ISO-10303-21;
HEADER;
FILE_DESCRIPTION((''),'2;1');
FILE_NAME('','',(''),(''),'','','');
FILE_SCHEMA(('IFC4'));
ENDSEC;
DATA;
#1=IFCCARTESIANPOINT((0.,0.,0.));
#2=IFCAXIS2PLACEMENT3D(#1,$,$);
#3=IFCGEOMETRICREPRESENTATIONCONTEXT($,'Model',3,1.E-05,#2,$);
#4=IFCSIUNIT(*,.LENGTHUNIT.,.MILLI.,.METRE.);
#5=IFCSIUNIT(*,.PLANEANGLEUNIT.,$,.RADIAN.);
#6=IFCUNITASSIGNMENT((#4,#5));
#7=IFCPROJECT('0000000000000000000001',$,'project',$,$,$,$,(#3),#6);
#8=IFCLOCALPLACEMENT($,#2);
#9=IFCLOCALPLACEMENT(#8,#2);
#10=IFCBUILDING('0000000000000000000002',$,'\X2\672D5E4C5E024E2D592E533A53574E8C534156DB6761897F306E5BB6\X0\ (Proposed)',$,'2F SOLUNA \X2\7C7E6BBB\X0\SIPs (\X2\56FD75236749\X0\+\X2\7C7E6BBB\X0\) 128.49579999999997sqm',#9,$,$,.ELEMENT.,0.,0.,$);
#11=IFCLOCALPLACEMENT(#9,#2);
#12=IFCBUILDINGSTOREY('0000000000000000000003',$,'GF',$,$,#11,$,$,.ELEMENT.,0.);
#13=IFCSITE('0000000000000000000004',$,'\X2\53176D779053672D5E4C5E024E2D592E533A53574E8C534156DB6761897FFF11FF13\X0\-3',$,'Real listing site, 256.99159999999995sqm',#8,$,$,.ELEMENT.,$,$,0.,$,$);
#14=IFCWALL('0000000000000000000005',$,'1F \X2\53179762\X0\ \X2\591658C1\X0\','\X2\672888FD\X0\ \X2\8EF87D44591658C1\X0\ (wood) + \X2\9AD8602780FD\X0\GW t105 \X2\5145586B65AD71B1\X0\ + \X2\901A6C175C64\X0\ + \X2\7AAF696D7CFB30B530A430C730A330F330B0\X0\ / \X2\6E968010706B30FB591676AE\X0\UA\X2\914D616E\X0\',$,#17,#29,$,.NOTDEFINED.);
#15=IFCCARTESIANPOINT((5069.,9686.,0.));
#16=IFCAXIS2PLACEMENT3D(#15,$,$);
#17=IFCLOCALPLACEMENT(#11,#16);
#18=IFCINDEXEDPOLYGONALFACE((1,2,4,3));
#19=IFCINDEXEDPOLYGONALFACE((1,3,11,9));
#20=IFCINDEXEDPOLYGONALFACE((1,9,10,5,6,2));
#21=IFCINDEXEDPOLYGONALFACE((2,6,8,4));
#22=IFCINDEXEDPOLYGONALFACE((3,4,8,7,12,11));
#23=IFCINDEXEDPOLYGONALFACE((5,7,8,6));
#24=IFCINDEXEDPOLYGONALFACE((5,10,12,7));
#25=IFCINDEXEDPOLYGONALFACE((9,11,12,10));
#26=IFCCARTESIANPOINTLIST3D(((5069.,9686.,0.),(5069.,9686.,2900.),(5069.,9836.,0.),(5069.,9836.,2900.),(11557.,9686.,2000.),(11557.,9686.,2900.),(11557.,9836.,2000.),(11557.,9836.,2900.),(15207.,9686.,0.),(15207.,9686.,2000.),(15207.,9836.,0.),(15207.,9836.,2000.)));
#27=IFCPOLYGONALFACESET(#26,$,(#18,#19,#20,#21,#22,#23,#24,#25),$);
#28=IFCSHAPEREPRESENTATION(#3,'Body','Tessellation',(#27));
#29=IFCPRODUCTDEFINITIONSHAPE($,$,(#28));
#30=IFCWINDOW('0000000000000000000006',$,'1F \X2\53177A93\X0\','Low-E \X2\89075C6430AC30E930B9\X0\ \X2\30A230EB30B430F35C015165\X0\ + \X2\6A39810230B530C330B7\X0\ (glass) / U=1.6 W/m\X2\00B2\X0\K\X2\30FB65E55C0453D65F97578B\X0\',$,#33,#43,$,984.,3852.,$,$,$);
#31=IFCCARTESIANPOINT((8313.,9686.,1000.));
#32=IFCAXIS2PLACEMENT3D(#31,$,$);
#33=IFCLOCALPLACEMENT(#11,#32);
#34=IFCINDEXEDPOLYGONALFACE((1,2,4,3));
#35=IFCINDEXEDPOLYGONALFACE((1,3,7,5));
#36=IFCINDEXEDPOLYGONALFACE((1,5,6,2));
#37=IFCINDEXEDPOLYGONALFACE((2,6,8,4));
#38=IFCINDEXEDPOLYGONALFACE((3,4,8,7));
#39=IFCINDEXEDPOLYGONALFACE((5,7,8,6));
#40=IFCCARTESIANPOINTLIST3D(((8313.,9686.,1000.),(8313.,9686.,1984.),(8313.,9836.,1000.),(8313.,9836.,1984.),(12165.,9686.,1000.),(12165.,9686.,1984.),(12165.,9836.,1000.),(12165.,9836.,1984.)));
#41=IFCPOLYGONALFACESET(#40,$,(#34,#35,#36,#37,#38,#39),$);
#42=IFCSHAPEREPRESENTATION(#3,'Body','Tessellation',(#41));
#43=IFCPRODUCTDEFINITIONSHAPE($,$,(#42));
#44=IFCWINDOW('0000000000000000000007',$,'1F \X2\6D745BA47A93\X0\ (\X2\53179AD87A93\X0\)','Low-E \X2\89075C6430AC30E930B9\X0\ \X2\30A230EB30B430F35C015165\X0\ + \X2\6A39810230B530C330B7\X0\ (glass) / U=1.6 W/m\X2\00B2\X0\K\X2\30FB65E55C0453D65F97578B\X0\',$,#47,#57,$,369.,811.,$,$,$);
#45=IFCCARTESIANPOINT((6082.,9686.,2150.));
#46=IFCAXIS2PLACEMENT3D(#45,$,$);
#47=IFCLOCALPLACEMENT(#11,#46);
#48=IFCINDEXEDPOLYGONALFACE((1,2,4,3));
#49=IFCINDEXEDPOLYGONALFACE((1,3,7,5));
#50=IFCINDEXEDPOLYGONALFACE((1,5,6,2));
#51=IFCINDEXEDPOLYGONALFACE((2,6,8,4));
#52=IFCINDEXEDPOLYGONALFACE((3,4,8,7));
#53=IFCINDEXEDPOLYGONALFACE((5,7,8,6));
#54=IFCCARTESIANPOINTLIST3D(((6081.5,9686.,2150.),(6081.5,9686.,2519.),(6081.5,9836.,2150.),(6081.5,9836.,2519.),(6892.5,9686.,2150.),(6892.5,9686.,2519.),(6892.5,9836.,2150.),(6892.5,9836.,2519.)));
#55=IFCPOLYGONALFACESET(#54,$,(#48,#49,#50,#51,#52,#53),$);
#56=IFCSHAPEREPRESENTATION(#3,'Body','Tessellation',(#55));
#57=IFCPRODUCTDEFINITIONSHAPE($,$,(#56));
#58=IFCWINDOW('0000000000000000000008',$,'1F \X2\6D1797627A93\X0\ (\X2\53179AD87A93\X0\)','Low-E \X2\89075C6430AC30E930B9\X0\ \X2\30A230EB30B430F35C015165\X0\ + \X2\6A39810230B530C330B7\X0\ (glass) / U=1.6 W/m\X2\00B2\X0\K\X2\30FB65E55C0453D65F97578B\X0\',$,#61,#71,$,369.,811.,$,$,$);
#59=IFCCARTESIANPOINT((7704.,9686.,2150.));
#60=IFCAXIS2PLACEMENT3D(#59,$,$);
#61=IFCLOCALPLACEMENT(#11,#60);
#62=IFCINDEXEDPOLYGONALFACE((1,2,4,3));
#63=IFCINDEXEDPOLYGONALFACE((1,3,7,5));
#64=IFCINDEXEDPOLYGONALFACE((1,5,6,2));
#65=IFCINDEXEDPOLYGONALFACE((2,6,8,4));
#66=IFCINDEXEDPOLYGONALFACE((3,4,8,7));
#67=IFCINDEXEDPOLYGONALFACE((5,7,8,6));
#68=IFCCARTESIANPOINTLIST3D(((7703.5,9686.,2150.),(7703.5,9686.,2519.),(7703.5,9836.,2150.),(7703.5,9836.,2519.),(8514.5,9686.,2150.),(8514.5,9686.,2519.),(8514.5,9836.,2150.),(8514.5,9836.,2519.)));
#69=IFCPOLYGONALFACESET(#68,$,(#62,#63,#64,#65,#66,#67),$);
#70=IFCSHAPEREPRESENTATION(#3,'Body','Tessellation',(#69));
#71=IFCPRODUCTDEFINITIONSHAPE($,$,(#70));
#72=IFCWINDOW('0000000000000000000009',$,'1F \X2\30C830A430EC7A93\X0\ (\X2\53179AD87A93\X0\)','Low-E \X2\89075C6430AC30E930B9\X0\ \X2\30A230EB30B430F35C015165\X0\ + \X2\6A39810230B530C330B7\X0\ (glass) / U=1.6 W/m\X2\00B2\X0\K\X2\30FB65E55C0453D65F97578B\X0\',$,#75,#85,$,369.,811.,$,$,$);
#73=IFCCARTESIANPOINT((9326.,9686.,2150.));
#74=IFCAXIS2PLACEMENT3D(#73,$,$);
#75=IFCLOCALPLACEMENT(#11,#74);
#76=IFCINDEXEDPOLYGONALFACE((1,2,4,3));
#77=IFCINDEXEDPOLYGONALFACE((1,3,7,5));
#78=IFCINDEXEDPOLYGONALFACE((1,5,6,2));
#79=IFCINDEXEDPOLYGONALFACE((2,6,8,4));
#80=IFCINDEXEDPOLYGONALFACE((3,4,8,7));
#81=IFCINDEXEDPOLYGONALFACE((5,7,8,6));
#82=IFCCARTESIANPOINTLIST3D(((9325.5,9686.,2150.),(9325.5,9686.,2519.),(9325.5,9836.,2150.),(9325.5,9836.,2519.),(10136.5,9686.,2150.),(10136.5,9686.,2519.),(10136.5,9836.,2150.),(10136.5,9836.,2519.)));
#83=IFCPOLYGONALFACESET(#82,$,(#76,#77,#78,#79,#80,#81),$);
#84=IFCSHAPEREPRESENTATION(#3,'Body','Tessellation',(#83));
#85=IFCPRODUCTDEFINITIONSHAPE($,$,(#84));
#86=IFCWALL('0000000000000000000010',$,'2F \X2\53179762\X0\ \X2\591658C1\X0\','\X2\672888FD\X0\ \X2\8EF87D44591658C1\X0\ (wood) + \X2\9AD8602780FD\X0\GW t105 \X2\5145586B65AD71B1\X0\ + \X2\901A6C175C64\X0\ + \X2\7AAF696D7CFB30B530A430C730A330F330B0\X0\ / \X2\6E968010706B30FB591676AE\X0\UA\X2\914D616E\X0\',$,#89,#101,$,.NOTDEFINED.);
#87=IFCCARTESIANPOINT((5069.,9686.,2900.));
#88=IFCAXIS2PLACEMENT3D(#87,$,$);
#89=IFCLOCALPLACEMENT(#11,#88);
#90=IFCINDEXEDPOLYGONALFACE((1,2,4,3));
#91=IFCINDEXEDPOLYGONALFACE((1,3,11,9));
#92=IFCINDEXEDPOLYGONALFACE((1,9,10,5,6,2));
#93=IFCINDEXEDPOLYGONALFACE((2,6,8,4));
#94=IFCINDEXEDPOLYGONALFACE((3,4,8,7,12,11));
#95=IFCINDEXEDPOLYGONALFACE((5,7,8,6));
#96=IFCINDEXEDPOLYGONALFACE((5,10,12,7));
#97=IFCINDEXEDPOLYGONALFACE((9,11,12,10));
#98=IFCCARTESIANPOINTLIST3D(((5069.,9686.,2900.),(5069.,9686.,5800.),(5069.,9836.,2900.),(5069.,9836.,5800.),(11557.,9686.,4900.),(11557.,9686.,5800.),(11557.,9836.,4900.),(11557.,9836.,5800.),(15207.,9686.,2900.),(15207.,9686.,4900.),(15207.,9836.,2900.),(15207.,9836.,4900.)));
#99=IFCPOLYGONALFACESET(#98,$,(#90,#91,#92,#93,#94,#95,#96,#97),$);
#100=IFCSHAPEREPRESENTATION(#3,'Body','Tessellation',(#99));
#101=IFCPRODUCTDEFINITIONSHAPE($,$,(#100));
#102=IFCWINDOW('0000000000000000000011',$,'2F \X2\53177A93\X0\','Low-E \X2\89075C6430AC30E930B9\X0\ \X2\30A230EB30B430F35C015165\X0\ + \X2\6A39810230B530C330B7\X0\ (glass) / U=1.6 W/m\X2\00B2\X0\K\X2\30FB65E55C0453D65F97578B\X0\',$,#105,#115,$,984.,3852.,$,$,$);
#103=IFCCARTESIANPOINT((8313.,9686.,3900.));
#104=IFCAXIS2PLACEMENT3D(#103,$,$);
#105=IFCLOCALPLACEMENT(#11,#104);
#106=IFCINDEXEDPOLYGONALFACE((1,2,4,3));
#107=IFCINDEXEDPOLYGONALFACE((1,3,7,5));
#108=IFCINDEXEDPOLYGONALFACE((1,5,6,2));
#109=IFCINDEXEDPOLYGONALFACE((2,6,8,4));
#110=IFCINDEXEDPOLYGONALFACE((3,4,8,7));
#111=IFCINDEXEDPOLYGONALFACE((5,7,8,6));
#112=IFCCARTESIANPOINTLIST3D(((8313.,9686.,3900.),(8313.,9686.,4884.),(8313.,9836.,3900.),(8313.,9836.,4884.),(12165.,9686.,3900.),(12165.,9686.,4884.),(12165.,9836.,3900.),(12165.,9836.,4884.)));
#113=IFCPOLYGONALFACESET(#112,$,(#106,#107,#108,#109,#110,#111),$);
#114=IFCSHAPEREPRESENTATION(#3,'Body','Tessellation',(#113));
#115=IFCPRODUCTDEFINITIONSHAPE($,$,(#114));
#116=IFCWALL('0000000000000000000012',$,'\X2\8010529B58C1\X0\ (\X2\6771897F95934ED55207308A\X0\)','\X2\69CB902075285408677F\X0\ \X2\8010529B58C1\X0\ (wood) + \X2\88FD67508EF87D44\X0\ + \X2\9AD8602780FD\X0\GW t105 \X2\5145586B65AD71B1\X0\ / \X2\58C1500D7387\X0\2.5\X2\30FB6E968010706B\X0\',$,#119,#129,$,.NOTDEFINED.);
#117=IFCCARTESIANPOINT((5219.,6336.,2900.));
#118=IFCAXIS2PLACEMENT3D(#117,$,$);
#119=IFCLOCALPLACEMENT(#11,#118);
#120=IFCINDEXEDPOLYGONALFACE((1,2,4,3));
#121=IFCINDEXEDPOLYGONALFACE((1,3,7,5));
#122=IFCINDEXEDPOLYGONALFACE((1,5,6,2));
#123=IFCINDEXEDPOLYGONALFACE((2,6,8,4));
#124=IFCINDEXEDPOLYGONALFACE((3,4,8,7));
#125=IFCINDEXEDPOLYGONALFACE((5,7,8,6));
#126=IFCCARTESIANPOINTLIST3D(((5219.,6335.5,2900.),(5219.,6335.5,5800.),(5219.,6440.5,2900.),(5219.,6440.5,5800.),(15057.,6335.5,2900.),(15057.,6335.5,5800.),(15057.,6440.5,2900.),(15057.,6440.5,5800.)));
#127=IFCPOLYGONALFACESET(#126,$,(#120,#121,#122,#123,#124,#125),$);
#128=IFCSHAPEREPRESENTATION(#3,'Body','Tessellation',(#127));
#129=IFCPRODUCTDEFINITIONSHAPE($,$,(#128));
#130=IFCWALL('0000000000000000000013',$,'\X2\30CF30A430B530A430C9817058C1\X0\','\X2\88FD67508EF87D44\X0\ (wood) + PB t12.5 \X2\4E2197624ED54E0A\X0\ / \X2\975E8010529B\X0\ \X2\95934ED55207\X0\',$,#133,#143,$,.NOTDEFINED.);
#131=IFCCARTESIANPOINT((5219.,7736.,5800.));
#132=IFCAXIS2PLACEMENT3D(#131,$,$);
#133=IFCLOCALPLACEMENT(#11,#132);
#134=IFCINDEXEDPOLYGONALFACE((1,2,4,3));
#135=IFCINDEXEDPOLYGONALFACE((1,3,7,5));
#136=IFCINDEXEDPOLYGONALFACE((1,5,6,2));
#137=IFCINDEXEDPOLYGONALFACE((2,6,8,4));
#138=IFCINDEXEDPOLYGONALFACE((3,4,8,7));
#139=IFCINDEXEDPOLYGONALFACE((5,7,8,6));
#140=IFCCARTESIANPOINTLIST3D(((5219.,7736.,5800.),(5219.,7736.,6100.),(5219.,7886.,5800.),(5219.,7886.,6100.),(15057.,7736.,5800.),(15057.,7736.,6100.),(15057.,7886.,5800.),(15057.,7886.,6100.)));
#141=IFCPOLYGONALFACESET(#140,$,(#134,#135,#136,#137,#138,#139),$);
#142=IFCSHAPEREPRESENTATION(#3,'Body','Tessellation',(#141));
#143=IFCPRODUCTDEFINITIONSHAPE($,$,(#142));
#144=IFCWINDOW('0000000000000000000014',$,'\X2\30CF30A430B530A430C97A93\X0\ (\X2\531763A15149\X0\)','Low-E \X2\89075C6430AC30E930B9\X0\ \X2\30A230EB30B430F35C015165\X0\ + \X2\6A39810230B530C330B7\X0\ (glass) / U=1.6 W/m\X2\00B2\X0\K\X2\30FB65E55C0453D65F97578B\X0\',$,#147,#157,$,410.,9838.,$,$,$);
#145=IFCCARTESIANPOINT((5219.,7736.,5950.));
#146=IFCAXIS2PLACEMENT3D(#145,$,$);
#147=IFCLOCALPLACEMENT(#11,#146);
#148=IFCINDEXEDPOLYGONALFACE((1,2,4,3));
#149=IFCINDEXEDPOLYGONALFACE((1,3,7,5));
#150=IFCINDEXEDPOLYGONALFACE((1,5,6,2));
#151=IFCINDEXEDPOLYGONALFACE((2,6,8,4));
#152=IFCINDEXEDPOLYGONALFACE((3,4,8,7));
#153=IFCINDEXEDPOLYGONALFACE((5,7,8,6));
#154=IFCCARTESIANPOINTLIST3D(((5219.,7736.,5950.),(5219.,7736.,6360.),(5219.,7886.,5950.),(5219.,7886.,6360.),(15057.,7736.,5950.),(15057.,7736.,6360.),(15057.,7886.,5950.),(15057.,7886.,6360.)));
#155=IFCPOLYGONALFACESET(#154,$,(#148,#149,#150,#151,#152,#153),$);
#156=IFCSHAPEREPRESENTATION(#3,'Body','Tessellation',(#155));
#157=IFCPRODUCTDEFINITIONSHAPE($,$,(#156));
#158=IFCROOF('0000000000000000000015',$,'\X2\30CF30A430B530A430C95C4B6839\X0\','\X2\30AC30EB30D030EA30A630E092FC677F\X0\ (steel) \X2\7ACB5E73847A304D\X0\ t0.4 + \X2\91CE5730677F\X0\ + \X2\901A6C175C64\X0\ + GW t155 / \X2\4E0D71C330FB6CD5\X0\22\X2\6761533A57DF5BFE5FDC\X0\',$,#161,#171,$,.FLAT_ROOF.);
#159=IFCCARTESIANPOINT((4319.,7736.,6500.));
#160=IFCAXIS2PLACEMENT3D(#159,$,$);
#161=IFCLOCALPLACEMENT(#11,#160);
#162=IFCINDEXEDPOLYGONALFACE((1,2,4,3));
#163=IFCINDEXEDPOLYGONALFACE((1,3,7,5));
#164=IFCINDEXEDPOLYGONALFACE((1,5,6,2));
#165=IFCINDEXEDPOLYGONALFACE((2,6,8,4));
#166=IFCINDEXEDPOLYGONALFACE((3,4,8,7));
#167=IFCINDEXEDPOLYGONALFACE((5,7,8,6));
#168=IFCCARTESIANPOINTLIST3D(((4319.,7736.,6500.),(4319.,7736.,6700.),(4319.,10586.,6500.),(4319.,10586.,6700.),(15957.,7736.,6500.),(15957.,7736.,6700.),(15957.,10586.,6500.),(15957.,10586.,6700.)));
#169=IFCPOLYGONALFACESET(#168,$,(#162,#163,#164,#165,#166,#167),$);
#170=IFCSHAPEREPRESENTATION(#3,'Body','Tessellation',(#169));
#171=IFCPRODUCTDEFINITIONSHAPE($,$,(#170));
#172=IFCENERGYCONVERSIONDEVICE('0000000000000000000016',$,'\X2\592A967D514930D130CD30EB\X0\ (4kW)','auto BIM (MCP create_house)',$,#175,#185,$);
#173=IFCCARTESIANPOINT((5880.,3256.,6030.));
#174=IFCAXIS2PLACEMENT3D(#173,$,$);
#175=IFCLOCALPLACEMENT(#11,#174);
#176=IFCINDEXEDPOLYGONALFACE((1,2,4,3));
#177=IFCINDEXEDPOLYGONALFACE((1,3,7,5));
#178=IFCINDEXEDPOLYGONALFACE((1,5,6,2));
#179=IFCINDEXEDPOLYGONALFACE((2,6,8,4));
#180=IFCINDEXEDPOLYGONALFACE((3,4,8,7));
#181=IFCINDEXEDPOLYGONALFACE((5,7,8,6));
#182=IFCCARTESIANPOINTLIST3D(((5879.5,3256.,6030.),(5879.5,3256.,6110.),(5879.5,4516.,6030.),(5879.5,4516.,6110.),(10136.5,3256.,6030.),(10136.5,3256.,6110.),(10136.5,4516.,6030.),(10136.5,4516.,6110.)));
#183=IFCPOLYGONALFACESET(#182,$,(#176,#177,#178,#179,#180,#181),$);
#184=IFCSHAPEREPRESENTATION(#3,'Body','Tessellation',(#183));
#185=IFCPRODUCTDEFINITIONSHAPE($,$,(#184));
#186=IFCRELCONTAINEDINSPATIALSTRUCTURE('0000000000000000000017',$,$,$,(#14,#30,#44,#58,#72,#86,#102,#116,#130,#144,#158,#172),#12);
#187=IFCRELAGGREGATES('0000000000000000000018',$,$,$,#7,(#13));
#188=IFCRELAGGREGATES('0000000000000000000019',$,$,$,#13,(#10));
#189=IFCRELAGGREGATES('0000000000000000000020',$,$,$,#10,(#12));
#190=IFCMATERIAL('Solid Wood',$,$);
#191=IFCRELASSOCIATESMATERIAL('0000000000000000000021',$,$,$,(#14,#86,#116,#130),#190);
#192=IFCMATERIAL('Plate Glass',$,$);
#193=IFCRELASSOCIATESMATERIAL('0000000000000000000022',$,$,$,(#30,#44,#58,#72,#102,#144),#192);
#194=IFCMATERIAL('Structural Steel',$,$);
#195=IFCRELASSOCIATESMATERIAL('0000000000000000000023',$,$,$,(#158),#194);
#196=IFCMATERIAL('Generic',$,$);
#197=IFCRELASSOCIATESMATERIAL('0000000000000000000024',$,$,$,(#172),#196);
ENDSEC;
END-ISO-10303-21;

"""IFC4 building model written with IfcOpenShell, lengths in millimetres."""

from ifc_helpers import new_model, si_unit, frame, frame_2d, origin, place, context, project, spatial, rectangle, extrude, material, element, fill, save


model = new_model("IFC4")

# Units and contexts
model_context = context("Model", 3, precision=1e-05, world=origin())
ifc_project = project(units=[si_unit("LENGTHUNIT", "METRE", prefix="MILLI"), si_unit("PLANEANGLEUNIT", "RADIAN")], contexts=[model_context])

# Site, building, storey
site_placement = place(None, origin())
site = spatial("IfcSite", under=ifc_project, at=site_placement, Name="北海道札幌市中央区南二十四条西１３-3", ObjectType="Real listing site, 256.99159999999995sqm", CompositionType="ELEMENT", RefElevation=0.0)
building_placement = place(site_placement, origin())
building = spatial("IfcBuilding", under=site, at=building_placement, Name="札幌市中央区南二十四条西の家 (Proposed)", ObjectType="2F SOLUNA 籾殻SIPs (国産杉+籾殻) 128.49579999999997sqm", CompositionType="ELEMENT", ElevationOfRefHeight=0.0, ElevationOfTerrain=0.0)
storey_placement = place(building_placement, origin())
storey = spatial("IfcBuildingStorey", under=building, at=storey_placement, Name="GF", CompositionType="ELEMENT", Elevation=0.0)

# Wall, openings, windows
ifc_material_1 = material(Name="Solid Wood")
wall_1_placement = place(storey_placement, frame((5069.0, 9686.0, 0.0)))
wall_1 = element("IfcWall", 1, at=wall_1_placement, inside=storey, material=ifc_material_1, Name="1F 北面 外壁", Description="木製 軸組外壁 (wood) + 高性能GW t105 充填断熱 + 通気層 + 窯業系サイディング / 準耐火・外皮UA配慮", PredefinedType="NOTDEFINED", context=model_context, shape_type="SweptSolid", body=[
    extrude(rectangle(XDim=10138.0, YDim=150.0, at=frame_2d((5069.0, 75.0))), frame((5069.0, 9686.0, 0.0)), (0.0, 0.0, 1.0), 2900.0),
])
opening_1_placement = place(storey_placement, frame((8313.0, 9686.0, 1000.0)))
opening_1 = element("IfcOpeningElement", 2, at=opening_1_placement, cuts=wall_1, PredefinedType="NOTDEFINED", context=model_context, shape_type="SweptSolid", body=[
    extrude(rectangle(XDim=3852.0, YDim=150.0, at=frame_2d((1926.0, 75.0))), frame((8313.0, 9686.0, 1000.0)), (0.0, 0.0, 1.0), 984.0),
])
opening_2_placement = place(storey_placement, frame((6082.0, 9686.0, 2150.0)))
opening_2 = element("IfcOpeningElement", 3, at=opening_2_placement, cuts=wall_1, PredefinedType="NOTDEFINED", context=model_context, shape_type="SweptSolid", body=[
    extrude(rectangle(XDim=811.0, YDim=150.0, at=frame_2d((405.0, 75.0))), frame((6082.0, 9686.0, 2150.0)), (0.0, 0.0, 1.0), 369.0),
])
opening_3_placement = place(storey_placement, frame((7704.0, 9686.0, 2150.0)))
opening_3 = element("IfcOpeningElement", 4, at=opening_3_placement, cuts=wall_1, PredefinedType="NOTDEFINED", context=model_context, shape_type="SweptSolid", body=[
    extrude(rectangle(XDim=811.0, YDim=150.0, at=frame_2d((405.0, 75.0))), frame((7704.0, 9686.0, 2150.0)), (0.0, 0.0, 1.0), 369.0),
])
opening_4_placement = place(storey_placement, frame((9326.0, 9686.0, 2150.0)))
opening_4 = element("IfcOpeningElement", 5, at=opening_4_placement, cuts=wall_1, PredefinedType="NOTDEFINED", context=model_context, shape_type="SweptSolid", body=[
    extrude(rectangle(XDim=811.0, YDim=150.0, at=frame_2d((405.0, 75.0))), frame((9326.0, 9686.0, 2150.0)), (0.0, 0.0, 1.0), 369.0),
])
ifc_material_2 = material(Name="Plate Glass")
window_1_placement = place(storey_placement, frame((8313.0, 9686.0, 1000.0)))
window_1 = element("IfcWindow", 6, at=window_1_placement, inside=storey, material=ifc_material_2, Name="1F 北窓", Description="Low-E 複層ガラス アルゴン封入 + 樹脂サッシ (glass) / U=1.6 W/m²K・日射取得型", OverallHeight=984.0, OverallWidth=3852.0, context=model_context, shape_type="SweptSolid", body=[
    extrude(rectangle(XDim=3852.0, YDim=150.0, at=frame_2d((1926.0, 75.0))), frame((8313.0, 9686.0, 1000.0)), (0.0, 0.0, 1.0), 984.0),
])
fill(opening_1, window_1)
window_2_placement = place(storey_placement, frame((6082.0, 9686.0, 2150.0)))
window_2 = element("IfcWindow", 7, at=window_2_placement, inside=storey, material=ifc_material_2, Name="1F 浴室窓 (北高窓)", Description="Low-E 複層ガラス アルゴン封入 + 樹脂サッシ (glass) / U=1.6 W/m²K・日射取得型", OverallHeight=369.0, OverallWidth=811.0, context=model_context, shape_type="SweptSolid", body=[
    extrude(rectangle(XDim=811.0, YDim=150.0, at=frame_2d((405.0, 75.0))), frame((6082.0, 9686.0, 2150.0)), (0.0, 0.0, 1.0), 369.0),
])
fill(opening_2, window_2)
window_3_placement = place(storey_placement, frame((7704.0, 9686.0, 2150.0)))
window_3 = element("IfcWindow", 8, at=window_3_placement, inside=storey, material=ifc_material_2, Name="1F 洗面窓 (北高窓)", Description="Low-E 複層ガラス アルゴン封入 + 樹脂サッシ (glass) / U=1.6 W/m²K・日射取得型", OverallHeight=369.0, OverallWidth=811.0, context=model_context, shape_type="SweptSolid", body=[
    extrude(rectangle(XDim=811.0, YDim=150.0, at=frame_2d((405.0, 75.0))), frame((7704.0, 9686.0, 2150.0)), (0.0, 0.0, 1.0), 369.0),
])
fill(opening_3, window_3)
window_4_placement = place(storey_placement, frame((9326.0, 9686.0, 2150.0)))
window_4 = element("IfcWindow", 9, at=window_4_placement, inside=storey, material=ifc_material_2, Name="1F トイレ窓 (北高窓)", Description="Low-E 複層ガラス アルゴン封入 + 樹脂サッシ (glass) / U=1.6 W/m²K・日射取得型", OverallHeight=369.0, OverallWidth=811.0, context=model_context, shape_type="SweptSolid", body=[
    extrude(rectangle(XDim=811.0, YDim=150.0, at=frame_2d((405.0, 75.0))), frame((9326.0, 9686.0, 2150.0)), (0.0, 0.0, 1.0), 369.0),
])
fill(opening_4, window_4)

# Wall, opening, window
wall_2_placement = place(storey_placement, frame((5069.0, 9686.0, 2900.0)))
wall_2 = element("IfcWall", 10, at=wall_2_placement, inside=storey, material=ifc_material_1, Name="2F 北面 外壁", Description="木製 軸組外壁 (wood) + 高性能GW t105 充填断熱 + 通気層 + 窯業系サイディング / 準耐火・外皮UA配慮", PredefinedType="NOTDEFINED", context=model_context, shape_type="SweptSolid", body=[
    extrude(rectangle(XDim=10138.0, YDim=150.0, at=frame_2d((5069.0, 75.0))), frame((5069.0, 9686.0, 2900.0)), (0.0, 0.0, 1.0), 2900.0),
])
opening_5_placement = place(storey_placement, frame((8313.0, 9686.0, 3900.0)))
opening_5 = element("IfcOpeningElement", 11, at=opening_5_placement, cuts=wall_2, PredefinedType="NOTDEFINED", context=model_context, shape_type="SweptSolid", body=[
    extrude(rectangle(XDim=3852.0, YDim=150.0, at=frame_2d((1926.0, 75.0))), frame((8313.0, 9686.0, 3900.0)), (0.0, 0.0, 1.0), 984.0),
])
window_5_placement = place(storey_placement, frame((8313.0, 9686.0, 3900.0)))
window_5 = element("IfcWindow", 12, at=window_5_placement, inside=storey, material=ifc_material_2, Name="2F 北窓", Description="Low-E 複層ガラス アルゴン封入 + 樹脂サッシ (glass) / U=1.6 W/m²K・日射取得型", OverallHeight=984.0, OverallWidth=3852.0, context=model_context, shape_type="SweptSolid", body=[
    extrude(rectangle(XDim=3852.0, YDim=150.0, at=frame_2d((1926.0, 75.0))), frame((8313.0, 9686.0, 3900.0)), (0.0, 0.0, 1.0), 984.0),
])
fill(opening_5, window_5)

# Wall
wall_3_placement = place(storey_placement, frame((5219.0, 6336.0, 2900.0)))
element("IfcWall", 13, at=wall_3_placement, inside=storey, material=ifc_material_1, Name="耐力壁 (東西間仕切り)", Description="構造用合板 耐力壁 (wood) + 製材軸組 + 高性能GW t105 充填断熱 / 壁倍率2.5・準耐火", PredefinedType="NOTDEFINED", context=model_context, shape_type="SweptSolid", body=[
    extrude(rectangle(XDim=9838.0, YDim=105.0, at=frame_2d((4919.0, 52.0))), frame((5219.0, 6336.0, 2900.0)), (0.0, 0.0, 1.0), 2900.0),
])

# Wall, opening, window
wall_4_placement = place(storey_placement, frame((5219.0, 7736.0, 5800.0)))
wall_4 = element("IfcWall", 14, at=wall_4_placement, inside=storey, material=ifc_material_1, Name="ハイサイド腰壁", Description="製材軸組 (wood) + PB t12.5 両面仕上 / 非耐力 間仕切", PredefinedType="NOTDEFINED", context=model_context, shape_type="SweptSolid", body=[
    extrude(rectangle(XDim=9838.0, YDim=150.0, at=frame_2d((4919.0, 75.0))), frame((5219.0, 7736.0, 5800.0)), (0.0, 0.0, 1.0), 700.0),
])
opening_6_placement = place(storey_placement, frame((5219.0, 7736.0, 5950.0)))
opening_6 = element("IfcOpeningElement", 15, at=opening_6_placement, cuts=wall_4, PredefinedType="NOTDEFINED", context=model_context, shape_type="SweptSolid", body=[
    extrude(rectangle(XDim=9838.0, YDim=150.0, at=frame_2d((4919.0, 75.0))), frame((5219.0, 7736.0, 5950.0)), (0.0, 0.0, 1.0), 410.0),
])
window_6_placement = place(storey_placement, frame((5219.0, 7736.0, 5950.0)))
window_6 = element("IfcWindow", 16, at=window_6_placement, inside=storey, material=ifc_material_2, Name="ハイサイド窓 (北採光)", Description="Low-E 複層ガラス アルゴン封入 + 樹脂サッシ (glass) / U=1.6 W/m²K・日射取得型", OverallHeight=410.0, OverallWidth=9838.0, context=model_context, shape_type="SweptSolid", body=[
    extrude(rectangle(XDim=9838.0, YDim=150.0, at=frame_2d((4919.0, 75.0))), frame((5219.0, 7736.0, 5950.0)), (0.0, 0.0, 1.0), 410.0),
])
fill(opening_6, window_6)

# Roof
ifc_material_3 = material(Name="Structural Steel")
roof_placement = place(storey_placement, frame((4319.0, 7736.0, 6500.0)))
element("IfcRoof", 17, at=roof_placement, inside=storey, material=ifc_material_3, Name="ハイサイド屋根", Description="ガルバリウム鋼板 (steel) 立平葺き t0.4 + 野地板 + 通気層 + GW t155 / 不燃・法22条区域対応", PredefinedType="FLAT_ROOF", context=model_context, shape_type="SweptSolid", body=[
    extrude(rectangle(XDim=11638.0, YDim=2850.0, at=frame_2d((5819.0, 1425.0))), frame((4319.0, 7736.0, 6500.0)), (0.0, 0.0, 1.0), 200.0),
])

# Energy conversion device
ifc_material_4 = material(Name="Generic")
energy_conversion_device_placement = place(storey_placement, frame((5880.0, 3256.0, 6030.0)))
element("IfcEnergyConversionDevice", 18, at=energy_conversion_device_placement, inside=storey, material=ifc_material_4, Name="太陽光パネル (4kW)", Description="auto BIM (MCP create_house)", context=model_context, shape_type="SweptSolid", body=[
    extrude(rectangle(XDim=4257.0, YDim=1260.0, at=frame_2d((2128.0, 630.0))), frame((5880.0, 3256.0, 6030.0)), (0.0, 0.0, 1.0), 80.0),
])

save(model, "model.ifc")
